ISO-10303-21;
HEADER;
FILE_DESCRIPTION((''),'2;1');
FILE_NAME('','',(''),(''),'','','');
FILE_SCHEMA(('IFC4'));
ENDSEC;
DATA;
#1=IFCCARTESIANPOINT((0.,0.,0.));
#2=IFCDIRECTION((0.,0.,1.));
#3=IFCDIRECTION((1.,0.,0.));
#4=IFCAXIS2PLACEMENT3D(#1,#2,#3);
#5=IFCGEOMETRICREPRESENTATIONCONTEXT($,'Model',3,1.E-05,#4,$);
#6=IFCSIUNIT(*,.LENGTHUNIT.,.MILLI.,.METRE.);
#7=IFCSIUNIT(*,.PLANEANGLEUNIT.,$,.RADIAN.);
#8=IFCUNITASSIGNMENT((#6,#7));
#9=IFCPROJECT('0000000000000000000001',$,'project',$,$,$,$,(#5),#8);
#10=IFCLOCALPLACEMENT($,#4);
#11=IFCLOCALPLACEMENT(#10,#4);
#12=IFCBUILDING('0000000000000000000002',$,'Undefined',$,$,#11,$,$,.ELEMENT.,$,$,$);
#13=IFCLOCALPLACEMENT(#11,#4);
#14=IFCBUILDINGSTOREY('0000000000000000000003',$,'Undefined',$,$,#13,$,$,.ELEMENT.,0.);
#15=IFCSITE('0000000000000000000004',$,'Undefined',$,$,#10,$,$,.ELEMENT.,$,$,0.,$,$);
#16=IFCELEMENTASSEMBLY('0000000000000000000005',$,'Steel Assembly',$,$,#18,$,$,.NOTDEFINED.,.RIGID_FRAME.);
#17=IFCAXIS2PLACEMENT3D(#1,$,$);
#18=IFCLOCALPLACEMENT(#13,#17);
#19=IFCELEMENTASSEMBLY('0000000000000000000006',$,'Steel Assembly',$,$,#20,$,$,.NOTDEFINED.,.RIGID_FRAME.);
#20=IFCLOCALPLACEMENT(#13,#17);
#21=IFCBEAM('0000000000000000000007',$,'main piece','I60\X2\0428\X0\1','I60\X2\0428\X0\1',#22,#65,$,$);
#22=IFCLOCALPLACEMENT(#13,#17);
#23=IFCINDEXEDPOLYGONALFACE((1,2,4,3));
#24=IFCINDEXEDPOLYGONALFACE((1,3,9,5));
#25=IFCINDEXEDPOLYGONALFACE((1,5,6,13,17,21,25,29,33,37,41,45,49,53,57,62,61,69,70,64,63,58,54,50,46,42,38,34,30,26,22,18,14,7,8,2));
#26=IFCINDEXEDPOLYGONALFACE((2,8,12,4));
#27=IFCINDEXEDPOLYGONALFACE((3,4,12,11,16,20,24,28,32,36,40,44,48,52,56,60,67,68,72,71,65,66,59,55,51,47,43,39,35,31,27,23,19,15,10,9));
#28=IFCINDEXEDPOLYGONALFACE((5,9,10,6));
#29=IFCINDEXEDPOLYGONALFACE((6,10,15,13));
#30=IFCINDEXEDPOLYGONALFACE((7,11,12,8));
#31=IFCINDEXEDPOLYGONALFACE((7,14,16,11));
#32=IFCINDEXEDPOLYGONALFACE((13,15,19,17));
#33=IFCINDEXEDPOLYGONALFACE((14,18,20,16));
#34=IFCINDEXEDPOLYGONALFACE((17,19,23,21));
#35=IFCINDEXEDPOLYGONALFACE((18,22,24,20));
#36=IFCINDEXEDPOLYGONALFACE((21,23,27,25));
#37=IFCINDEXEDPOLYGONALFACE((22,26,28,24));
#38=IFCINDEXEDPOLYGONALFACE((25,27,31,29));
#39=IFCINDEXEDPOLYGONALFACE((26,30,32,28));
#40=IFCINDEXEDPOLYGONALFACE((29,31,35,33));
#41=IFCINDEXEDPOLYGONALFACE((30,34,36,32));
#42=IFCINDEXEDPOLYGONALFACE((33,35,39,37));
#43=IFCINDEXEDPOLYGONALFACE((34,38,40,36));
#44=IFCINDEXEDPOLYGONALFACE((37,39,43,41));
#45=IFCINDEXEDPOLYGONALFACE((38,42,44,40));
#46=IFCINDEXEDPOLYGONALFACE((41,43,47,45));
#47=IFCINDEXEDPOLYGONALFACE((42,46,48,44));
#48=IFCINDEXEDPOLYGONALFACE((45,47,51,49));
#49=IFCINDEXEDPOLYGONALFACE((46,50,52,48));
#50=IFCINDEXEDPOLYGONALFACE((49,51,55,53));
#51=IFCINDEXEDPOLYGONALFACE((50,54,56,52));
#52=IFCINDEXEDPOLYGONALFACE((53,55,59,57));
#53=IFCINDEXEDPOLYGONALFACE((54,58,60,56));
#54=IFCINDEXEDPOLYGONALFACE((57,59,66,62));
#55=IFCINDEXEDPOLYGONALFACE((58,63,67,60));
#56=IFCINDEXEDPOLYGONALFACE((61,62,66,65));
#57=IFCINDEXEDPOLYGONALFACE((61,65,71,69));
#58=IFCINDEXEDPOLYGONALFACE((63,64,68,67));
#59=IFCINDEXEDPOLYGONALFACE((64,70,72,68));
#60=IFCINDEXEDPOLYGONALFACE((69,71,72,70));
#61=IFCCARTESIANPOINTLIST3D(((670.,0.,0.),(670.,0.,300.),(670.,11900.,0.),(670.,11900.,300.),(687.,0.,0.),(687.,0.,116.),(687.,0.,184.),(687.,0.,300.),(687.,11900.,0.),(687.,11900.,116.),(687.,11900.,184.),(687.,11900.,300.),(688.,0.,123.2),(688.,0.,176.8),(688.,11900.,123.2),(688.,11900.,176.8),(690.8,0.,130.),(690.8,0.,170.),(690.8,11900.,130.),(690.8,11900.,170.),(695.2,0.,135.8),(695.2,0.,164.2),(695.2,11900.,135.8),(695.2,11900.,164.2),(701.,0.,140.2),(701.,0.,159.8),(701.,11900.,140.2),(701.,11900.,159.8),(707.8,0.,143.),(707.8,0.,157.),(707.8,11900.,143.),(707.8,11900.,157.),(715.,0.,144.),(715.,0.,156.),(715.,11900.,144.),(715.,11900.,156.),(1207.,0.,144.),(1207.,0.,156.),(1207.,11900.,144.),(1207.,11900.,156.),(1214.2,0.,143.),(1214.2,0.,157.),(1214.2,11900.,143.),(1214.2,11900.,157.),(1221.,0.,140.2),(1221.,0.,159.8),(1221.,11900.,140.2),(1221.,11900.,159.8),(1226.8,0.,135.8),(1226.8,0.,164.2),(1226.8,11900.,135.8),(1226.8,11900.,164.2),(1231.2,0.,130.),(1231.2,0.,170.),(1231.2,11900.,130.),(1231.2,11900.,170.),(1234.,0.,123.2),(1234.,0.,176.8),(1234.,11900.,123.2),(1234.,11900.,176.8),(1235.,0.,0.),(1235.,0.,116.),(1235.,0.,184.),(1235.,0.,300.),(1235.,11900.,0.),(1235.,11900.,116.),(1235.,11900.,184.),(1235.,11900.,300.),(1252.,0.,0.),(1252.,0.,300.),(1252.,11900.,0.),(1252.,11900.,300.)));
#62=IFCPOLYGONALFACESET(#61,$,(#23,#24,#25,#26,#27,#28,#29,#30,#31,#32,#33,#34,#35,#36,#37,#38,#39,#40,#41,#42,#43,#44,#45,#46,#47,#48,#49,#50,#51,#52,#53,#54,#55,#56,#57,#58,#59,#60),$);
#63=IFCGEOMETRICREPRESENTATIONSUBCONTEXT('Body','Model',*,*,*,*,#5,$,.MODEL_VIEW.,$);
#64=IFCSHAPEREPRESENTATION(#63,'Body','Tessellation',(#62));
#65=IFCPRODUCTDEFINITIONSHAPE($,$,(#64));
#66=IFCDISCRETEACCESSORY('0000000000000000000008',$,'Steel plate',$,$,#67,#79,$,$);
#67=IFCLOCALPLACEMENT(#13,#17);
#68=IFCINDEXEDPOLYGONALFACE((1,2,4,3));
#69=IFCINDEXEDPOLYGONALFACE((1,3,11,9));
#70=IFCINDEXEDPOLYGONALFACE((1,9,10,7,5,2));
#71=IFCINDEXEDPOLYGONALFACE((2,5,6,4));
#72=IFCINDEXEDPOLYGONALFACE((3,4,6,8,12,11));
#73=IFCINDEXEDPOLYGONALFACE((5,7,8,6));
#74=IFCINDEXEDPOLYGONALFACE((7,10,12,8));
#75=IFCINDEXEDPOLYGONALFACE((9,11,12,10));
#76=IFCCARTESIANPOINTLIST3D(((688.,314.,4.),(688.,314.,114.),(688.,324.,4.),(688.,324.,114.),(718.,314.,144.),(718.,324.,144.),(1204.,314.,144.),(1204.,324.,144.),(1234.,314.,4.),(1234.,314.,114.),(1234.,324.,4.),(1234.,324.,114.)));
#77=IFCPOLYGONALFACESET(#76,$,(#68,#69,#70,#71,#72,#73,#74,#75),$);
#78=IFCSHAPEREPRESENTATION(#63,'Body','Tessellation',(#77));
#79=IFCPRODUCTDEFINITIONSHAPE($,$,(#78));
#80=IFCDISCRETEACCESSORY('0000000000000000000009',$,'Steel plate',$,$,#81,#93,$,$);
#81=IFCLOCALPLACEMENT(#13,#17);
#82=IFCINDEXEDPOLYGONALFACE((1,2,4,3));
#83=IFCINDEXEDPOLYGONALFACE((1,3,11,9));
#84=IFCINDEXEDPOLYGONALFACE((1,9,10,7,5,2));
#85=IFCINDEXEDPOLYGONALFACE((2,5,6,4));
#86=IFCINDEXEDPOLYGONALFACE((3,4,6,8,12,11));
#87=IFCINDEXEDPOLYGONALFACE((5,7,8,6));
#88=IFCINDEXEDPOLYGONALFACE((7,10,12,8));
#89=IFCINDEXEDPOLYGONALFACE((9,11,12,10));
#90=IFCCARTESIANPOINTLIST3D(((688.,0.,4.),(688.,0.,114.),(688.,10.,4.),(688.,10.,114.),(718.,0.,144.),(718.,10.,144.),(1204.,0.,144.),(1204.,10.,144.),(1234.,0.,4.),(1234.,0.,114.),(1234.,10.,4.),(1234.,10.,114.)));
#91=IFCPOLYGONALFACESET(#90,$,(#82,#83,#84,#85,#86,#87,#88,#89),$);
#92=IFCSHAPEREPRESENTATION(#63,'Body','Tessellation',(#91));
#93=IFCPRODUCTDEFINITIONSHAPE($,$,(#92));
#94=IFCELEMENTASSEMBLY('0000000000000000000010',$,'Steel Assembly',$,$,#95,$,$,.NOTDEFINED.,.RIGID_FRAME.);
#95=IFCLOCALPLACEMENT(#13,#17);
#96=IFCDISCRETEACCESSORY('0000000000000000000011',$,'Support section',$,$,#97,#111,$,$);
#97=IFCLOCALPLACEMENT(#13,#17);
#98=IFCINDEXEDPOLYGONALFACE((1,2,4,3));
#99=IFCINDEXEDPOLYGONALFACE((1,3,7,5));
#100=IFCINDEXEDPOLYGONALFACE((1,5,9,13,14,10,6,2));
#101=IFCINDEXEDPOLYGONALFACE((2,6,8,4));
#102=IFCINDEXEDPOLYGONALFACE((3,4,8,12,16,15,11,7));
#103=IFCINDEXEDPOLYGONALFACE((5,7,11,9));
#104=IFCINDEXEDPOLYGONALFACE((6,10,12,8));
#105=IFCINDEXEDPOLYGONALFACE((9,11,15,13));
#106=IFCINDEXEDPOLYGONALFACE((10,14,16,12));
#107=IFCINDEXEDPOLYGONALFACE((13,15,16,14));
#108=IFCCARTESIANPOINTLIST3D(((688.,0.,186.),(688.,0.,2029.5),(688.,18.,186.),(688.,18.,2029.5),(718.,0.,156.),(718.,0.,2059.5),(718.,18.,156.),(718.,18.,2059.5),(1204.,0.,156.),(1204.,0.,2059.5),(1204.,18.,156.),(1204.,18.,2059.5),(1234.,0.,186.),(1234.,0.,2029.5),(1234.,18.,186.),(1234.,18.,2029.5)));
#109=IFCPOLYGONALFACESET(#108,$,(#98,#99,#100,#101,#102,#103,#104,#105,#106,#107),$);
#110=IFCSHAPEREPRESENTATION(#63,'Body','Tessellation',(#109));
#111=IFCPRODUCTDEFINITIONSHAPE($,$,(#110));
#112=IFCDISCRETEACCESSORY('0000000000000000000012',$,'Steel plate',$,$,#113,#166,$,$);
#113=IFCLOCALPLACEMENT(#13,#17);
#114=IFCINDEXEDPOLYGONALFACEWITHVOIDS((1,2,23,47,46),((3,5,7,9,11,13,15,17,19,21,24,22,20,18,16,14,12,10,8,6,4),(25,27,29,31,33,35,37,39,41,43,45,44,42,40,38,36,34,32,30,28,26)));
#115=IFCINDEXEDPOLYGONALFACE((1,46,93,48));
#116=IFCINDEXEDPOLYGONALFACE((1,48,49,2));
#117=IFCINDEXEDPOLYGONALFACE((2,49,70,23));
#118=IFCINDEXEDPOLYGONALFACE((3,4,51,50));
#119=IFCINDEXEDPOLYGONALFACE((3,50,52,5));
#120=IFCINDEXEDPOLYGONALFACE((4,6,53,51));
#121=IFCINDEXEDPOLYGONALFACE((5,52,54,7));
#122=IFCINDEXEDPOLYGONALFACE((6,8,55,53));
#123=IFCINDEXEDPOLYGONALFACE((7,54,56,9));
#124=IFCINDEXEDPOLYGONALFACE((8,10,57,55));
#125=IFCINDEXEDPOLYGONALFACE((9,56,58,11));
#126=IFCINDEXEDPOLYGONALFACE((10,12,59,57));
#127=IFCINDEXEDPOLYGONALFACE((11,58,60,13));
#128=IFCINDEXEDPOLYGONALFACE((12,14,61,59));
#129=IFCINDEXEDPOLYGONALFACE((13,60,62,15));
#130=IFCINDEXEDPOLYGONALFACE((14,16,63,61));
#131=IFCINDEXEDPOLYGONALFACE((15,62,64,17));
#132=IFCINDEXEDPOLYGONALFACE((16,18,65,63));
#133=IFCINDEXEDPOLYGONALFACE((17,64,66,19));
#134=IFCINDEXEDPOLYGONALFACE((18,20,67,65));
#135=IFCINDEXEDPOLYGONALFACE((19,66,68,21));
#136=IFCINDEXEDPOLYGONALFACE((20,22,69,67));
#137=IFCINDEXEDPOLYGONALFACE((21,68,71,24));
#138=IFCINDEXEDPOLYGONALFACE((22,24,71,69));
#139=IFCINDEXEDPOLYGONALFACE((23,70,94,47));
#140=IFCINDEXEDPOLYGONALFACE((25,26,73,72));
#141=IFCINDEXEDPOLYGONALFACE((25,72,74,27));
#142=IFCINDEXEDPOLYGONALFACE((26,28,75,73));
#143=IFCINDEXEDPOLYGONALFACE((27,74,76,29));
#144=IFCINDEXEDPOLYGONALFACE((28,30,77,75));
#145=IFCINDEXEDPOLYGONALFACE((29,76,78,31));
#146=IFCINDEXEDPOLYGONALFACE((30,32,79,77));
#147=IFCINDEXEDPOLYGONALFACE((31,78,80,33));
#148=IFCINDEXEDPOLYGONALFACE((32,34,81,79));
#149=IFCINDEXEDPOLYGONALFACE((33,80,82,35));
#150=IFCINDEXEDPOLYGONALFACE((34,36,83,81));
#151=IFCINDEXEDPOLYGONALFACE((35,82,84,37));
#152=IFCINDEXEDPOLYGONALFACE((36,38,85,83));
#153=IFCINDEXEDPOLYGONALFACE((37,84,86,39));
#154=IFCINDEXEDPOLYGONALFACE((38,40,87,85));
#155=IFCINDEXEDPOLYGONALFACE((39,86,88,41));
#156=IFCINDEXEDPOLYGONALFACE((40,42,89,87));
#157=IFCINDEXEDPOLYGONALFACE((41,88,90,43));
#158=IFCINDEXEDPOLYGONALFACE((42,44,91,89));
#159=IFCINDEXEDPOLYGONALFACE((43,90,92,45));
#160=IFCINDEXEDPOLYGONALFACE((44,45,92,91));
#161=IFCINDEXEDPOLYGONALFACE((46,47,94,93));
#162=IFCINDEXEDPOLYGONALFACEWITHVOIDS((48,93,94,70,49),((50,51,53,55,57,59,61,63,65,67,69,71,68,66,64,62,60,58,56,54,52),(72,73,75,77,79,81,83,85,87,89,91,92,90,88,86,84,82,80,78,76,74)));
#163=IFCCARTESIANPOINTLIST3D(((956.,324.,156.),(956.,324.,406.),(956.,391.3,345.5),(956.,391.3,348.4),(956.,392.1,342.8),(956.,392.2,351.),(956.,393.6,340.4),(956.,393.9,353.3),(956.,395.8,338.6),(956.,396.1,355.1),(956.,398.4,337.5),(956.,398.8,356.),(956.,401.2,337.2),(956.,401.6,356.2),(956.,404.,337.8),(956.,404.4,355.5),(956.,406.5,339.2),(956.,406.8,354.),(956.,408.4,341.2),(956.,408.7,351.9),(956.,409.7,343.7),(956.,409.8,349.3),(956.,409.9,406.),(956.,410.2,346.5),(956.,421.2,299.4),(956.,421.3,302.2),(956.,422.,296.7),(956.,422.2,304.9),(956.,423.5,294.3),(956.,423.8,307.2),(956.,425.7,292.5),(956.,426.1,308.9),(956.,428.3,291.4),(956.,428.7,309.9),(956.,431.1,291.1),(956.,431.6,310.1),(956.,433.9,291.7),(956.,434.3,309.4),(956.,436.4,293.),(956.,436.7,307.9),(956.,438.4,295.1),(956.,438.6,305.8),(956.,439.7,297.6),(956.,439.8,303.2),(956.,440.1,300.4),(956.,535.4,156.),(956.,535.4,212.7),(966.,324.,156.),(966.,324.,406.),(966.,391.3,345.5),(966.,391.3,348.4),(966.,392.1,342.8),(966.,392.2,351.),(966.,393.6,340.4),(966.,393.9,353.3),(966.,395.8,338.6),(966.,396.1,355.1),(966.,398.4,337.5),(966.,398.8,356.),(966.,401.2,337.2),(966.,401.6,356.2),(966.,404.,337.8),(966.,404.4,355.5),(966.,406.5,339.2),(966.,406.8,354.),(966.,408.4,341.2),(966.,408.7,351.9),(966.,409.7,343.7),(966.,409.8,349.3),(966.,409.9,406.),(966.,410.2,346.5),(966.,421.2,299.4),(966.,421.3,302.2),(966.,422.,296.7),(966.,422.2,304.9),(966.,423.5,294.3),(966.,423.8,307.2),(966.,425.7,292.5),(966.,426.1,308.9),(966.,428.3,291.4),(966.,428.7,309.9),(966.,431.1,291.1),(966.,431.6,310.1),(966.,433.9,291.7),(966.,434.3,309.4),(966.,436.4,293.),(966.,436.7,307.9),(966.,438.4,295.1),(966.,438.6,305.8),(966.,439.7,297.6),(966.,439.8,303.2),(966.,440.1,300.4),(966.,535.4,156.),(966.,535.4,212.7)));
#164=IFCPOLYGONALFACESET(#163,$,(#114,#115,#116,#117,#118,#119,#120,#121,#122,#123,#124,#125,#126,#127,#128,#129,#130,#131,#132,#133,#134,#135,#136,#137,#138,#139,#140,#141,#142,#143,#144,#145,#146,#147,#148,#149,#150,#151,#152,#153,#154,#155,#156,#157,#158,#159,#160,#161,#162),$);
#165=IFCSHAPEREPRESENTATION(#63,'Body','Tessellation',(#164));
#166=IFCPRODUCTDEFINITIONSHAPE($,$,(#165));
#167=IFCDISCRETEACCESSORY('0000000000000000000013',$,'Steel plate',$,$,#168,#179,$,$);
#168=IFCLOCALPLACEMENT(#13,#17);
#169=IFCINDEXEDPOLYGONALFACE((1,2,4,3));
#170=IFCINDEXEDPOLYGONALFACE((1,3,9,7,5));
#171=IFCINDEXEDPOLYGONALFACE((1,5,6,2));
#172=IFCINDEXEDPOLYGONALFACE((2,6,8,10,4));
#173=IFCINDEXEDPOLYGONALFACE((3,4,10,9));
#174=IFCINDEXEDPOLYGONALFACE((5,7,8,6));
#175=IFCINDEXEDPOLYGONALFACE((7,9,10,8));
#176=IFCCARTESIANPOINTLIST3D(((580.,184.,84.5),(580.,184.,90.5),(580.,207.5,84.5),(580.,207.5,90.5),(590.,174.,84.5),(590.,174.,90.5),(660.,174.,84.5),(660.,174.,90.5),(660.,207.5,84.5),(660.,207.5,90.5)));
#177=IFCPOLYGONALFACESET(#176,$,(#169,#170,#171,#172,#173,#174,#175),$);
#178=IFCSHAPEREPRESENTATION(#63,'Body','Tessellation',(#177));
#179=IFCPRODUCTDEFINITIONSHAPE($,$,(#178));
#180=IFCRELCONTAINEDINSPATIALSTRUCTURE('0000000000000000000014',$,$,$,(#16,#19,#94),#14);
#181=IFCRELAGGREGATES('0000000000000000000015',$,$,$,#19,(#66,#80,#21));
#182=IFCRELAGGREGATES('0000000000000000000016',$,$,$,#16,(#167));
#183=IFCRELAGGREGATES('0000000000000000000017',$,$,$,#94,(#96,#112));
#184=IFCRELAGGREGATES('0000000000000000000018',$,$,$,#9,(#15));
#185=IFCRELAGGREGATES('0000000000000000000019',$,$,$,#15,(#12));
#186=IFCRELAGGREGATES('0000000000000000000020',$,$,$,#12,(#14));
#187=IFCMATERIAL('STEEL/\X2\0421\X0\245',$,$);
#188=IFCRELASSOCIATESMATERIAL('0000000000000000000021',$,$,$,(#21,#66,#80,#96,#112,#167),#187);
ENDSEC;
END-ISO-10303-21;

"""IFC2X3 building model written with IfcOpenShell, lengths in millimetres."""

from ifc_helpers import new_model, si_unit, frame, origin_with_axes, origin_2d_with_axis, place, context, subcontext, project, spatial, polyline, rectangle, circle, i_section, outline, extrude, source, transform, mapped, material, element, aggregate, save


model = new_model("IFC2X3")

# Units and contexts
model_context = context("Model", 3, precision=1e-05, world=origin_with_axes())
body_context = subcontext(model_context, "Body", "Model", "MODEL_VIEW")
ifc_project = project(units=[si_unit("LENGTHUNIT", "METRE", prefix="MILLI"), si_unit("PLANEANGLEUNIT", "RADIAN")], contexts=[model_context])

# Site, building, storey
site_placement = place(None, origin_with_axes())
site = spatial("IfcSite", under=ifc_project, at=site_placement, Name="Undefined", CompositionType="ELEMENT", RefElevation=0.0)
building_placement = place(site_placement, origin_with_axes())
building = spatial("IfcBuilding", under=site, at=building_placement, Name="Undefined", CompositionType="ELEMENT")
storey_placement = place(building_placement, origin_with_axes())
storey = spatial("IfcBuildingStorey", under=building, at=storey_placement, Name="Undefined", CompositionType="ELEMENT", Elevation=0.0)

# Element assembly
assembly_1_placement = place(storey_placement, origin_with_axes())
assembly_1 = element("IfcElementAssembly", 1, at=assembly_1_placement, inside=storey, Name="Steel Assembly", AssemblyPlace="NOTDEFINED", PredefinedType="RIGID_FRAME")
ifc_material_1 = material(Name="STEEL/С245")

# Element assembly, beam
assembly_2_placement = place(storey_placement, origin_with_axes())
assembly_2 = element("IfcElementAssembly", 2, at=assembly_2_placement, inside=storey, Name="Steel Assembly", AssemblyPlace="NOTDEFINED", PredefinedType="RIGID_FRAME")
beam_1_placement = place(assembly_2_placement, frame((961.0, 0.0, 150.0), z_axis=(-1.0, 0.0, 0.0), x_axis=(0.0, 1.0, 0.0)))
beam_1 = element("IfcBeam", 3, at=beam_1_placement, material=ifc_material_1, Name="main piece", Description="I60Ш1", ObjectType="I60Ш1", context=body_context, shape_type="SweptSolid", body=[
    extrude(i_section(OverallWidth=300.0, OverallDepth=582.0, WebThickness=12.0, FlangeThickness=17.0, FilletRadius=28.0, at=origin_2d_with_axis()), frame((11900.0, 0.0, 0.0), z_axis=(-1.0, 0.0, 0.0), x_axis=(0.0, -1.0, 0.0)), (0.0, 0.0, 1.0), 11900.0),
])

# Discrete accessories
discrete_accessory_1_placement = place(assembly_2_placement, frame((688.0, 319.0, 4.0), z_axis=(0.0, 1.0, 0.0), x_axis=(0.0, 0.0, 1.0)))
discrete_accessory_1 = element("IfcDiscreteAccessory", 4, at=discrete_accessory_1_placement, material=ifc_material_1, Name="Steel plate", context=body_context, shape_type="SweptSolid", body=[
    extrude(outline(polyline([(0.0, 0.0), (110.0, 0.0), (140.0, 30.0), (140.0, 516.0), (110.0, 546.0), (0.0, 546.0), (0.0, 0.0)])), frame((0.0, 0.0, -5.0), z_axis=(0.0, 0.0, 1.0), x_axis=(1.0, 0.0, 0.0)), (0.0, 0.0, 1.0), 10.0),
])
discrete_accessory_2_placement = place(assembly_2_placement, frame((688.0, 5.0, 4.0), z_axis=(0.0, 1.0, 0.0), x_axis=(0.0, 0.0, 1.0)))
discrete_accessory_2 = element("IfcDiscreteAccessory", 5, at=discrete_accessory_2_placement, material=ifc_material_1, Name="Steel plate", context=body_context, shape_type="SweptSolid", body=[
    extrude(outline(polyline([(0.0, 0.0), (110.0, 0.0), (140.0, 30.0), (140.0, 516.0), (110.0, 546.0), (0.0, 546.0), (0.0, 0.0)])), frame((0.0, 0.0, -5.0), z_axis=(0.0, 0.0, 1.0), x_axis=(1.0, 0.0, 0.0)), (0.0, 0.0, 1.0), 10.0),
])

# Element assembly, discrete accessories, openings
assembly_3_placement = place(storey_placement, origin_with_axes())
assembly_3 = element("IfcElementAssembly", 6, at=assembly_3_placement, inside=storey, Name="Steel Assembly", AssemblyPlace="NOTDEFINED", PredefinedType="RIGID_FRAME")
discrete_accessory_3_placement = place(assembly_3_placement, frame((961.0, 9.0, 156.0), z_axis=(0.0, 0.0, 1.0), x_axis=(1.0, 0.0, 0.0)))
discrete_accessory_3 = element("IfcDiscreteAccessory", 7, at=discrete_accessory_3_placement, material=ifc_material_1, Name="Support section", context=body_context, shape_type="SweptSolid", body=[
    extrude(rectangle(XDim=18.0, YDim=546.0, at=origin_2d_with_axis()), frame((0.0, 0.0, 1903.5), z_axis=(0.0, 0.0, -1.0), x_axis=(0.0, 1.0, 0.0)), (0.0, 0.0, 1.0), 1903.5),
])
opening_1_placement = place(assembly_3_placement, frame((961.0, 9.0, 156.0), z_axis=(0.0, 0.0, 1.0), x_axis=(1.0, 0.0, 0.0)))
element("IfcOpeningElement", 8, at=opening_1_placement, cuts=discrete_accessory_3, ObjectType="Recess", context=body_context, shape_type="SweptSolid", body=[
    extrude(outline(polyline([(0.0, 0.0), (30.0, 0.0), (0.0, 30.0), (0.0, 0.0)])), frame((273.0, 14.0, 0.0), z_axis=(0.0, -1.0, 0.0), x_axis=(0.0, 0.0, 1.0)), (0.0, 0.0, 1.0), 23.0),
])
opening_2_placement = place(assembly_3_placement, frame((961.0, 9.0, 156.0), z_axis=(0.0, 0.0, 1.0), x_axis=(1.0, 0.0, 0.0)))
element("IfcOpeningElement", 9, at=opening_2_placement, cuts=discrete_accessory_3, ObjectType="Recess", context=body_context, shape_type="SweptSolid", body=[
    extrude(outline(polyline([(0.0, 0.0), (30.0, 0.0), (0.0, 30.0), (0.0, 0.0)])), frame((-273.0, -9.0, 0.0), z_axis=(0.0, 1.0, 0.0), x_axis=(0.0, 0.0, 1.0)), (0.0, 0.0, 1.0), 23.0),
])
opening_3_placement = place(assembly_3_placement, frame((961.0, 9.0, 156.0), z_axis=(0.0, 0.0, 1.0), x_axis=(1.0, 0.0, 0.0)))
element("IfcOpeningElement", 10, at=opening_3_placement, cuts=discrete_accessory_3, ObjectType="Recess", context=body_context, shape_type="SweptSolid", body=[
    extrude(outline(polyline([(0.0, 0.0), (30.0, 0.0), (0.0, 30.0), (0.0, 0.0)])), frame((273.0, -11.9, 1903.5), z_axis=(0.0, 1.0, 0.0), x_axis=(0.0, 0.0, -1.0)), (0.0, 0.0, 1.0), 23.0),
])
opening_4_placement = place(assembly_3_placement, frame((961.0, 9.0, 156.0), z_axis=(0.0, 0.0, 1.0), x_axis=(1.0, 0.0, 0.0)))
element("IfcOpeningElement", 11, at=opening_4_placement, cuts=discrete_accessory_3, ObjectType="Recess", context=body_context, shape_type="SweptSolid", body=[
    extrude(outline(polyline([(0.0, 0.0), (30.0, 0.0), (0.0, 30.0), (0.0, 0.0)])), frame((-273.0, 11.1, 1903.5), z_axis=(0.0, -1.0, 0.0), x_axis=(0.0, 0.0, -1.0)), (0.0, 0.0, 1.0), 23.0),
])
discrete_accessory_4_placement = place(assembly_3_placement, frame((961.0, 324.0, 156.0), z_axis=(1.0, 0.0, 0.0), x_axis=(0.0, 1.0, 0.0)))
discrete_accessory_4 = element("IfcDiscreteAccessory", 12, at=discrete_accessory_4_placement, material=ifc_material_1, Name="Steel plate", context=body_context, shape_type="SweptSolid", body=[
    extrude(outline(polyline([(0.0, 0.0), (211.4, 0.0), (211.4, 56.7), (85.9, 250.0), (0.0, 250.0), (0.0, 0.0)])), frame((0.0, 0.0, -5.0), z_axis=(0.0, 0.0, 1.0), x_axis=(1.0, 0.0, 0.0)), (0.0, 0.0, 1.0), 10.0),
])
shared_shape_1 = source(origin_with_axes(), body_context, "Body", "SweptSolid", [
    extrude(circle(Radius=9.5, at=origin_2d_with_axis()), frame((0.0, 3.9, 0.0), z_axis=(0.0, 1.0, 0.0), x_axis=(1.0, 0.0, 0.0)), (0.0, 0.0, 1.0), 14.1),
])
opening_5_placement = place(assembly_3_placement, frame((970.0, 415.7, 323.7), z_axis=(0.0, -0.544395, 0.838829), x_axis=(0.0, 0.838829, 0.544395)))
element("IfcOpeningElement", 13, at=opening_5_placement, cuts=discrete_accessory_4, ObjectType="Opening", context=body_context, shape_type="MappedRepresentation", body=[
    mapped(shared_shape_1, transform((0.0, 0.0, -27.5))),
    mapped(shared_shape_1, transform((0.0, 0.0, 27.5))),
])

# Discrete accessory
discrete_accessory_5_placement = place(assembly_1_placement, frame((660.0, 207.5, 87.5), z_axis=(0.0, 0.0, 1.0), x_axis=(-1.0, 0.0, 0.0)))
discrete_accessory_5 = element("IfcDiscreteAccessory", 14, at=discrete_accessory_5_placement, material=ifc_material_1, Name="Steel plate", context=body_context, shape_type="SweptSolid", body=[
    extrude(outline(polyline([(0.0, 0.0), (80.0, 0.0), (80.0, 23.5), (70.0, 33.5), (0.0, 33.5), (0.0, 0.0)])), frame((0.0, 0.0, -3.0), z_axis=(0.0, 0.0, 1.0), x_axis=(1.0, 0.0, 0.0)), (0.0, 0.0, 1.0), 6.0),
])

aggregate(assembly_2, [discrete_accessory_1, discrete_accessory_2, beam_1])
aggregate(assembly_1, [discrete_accessory_5])

aggregate(assembly_3, [discrete_accessory_3, discrete_accessory_4])

save(model, "model.ifc")
